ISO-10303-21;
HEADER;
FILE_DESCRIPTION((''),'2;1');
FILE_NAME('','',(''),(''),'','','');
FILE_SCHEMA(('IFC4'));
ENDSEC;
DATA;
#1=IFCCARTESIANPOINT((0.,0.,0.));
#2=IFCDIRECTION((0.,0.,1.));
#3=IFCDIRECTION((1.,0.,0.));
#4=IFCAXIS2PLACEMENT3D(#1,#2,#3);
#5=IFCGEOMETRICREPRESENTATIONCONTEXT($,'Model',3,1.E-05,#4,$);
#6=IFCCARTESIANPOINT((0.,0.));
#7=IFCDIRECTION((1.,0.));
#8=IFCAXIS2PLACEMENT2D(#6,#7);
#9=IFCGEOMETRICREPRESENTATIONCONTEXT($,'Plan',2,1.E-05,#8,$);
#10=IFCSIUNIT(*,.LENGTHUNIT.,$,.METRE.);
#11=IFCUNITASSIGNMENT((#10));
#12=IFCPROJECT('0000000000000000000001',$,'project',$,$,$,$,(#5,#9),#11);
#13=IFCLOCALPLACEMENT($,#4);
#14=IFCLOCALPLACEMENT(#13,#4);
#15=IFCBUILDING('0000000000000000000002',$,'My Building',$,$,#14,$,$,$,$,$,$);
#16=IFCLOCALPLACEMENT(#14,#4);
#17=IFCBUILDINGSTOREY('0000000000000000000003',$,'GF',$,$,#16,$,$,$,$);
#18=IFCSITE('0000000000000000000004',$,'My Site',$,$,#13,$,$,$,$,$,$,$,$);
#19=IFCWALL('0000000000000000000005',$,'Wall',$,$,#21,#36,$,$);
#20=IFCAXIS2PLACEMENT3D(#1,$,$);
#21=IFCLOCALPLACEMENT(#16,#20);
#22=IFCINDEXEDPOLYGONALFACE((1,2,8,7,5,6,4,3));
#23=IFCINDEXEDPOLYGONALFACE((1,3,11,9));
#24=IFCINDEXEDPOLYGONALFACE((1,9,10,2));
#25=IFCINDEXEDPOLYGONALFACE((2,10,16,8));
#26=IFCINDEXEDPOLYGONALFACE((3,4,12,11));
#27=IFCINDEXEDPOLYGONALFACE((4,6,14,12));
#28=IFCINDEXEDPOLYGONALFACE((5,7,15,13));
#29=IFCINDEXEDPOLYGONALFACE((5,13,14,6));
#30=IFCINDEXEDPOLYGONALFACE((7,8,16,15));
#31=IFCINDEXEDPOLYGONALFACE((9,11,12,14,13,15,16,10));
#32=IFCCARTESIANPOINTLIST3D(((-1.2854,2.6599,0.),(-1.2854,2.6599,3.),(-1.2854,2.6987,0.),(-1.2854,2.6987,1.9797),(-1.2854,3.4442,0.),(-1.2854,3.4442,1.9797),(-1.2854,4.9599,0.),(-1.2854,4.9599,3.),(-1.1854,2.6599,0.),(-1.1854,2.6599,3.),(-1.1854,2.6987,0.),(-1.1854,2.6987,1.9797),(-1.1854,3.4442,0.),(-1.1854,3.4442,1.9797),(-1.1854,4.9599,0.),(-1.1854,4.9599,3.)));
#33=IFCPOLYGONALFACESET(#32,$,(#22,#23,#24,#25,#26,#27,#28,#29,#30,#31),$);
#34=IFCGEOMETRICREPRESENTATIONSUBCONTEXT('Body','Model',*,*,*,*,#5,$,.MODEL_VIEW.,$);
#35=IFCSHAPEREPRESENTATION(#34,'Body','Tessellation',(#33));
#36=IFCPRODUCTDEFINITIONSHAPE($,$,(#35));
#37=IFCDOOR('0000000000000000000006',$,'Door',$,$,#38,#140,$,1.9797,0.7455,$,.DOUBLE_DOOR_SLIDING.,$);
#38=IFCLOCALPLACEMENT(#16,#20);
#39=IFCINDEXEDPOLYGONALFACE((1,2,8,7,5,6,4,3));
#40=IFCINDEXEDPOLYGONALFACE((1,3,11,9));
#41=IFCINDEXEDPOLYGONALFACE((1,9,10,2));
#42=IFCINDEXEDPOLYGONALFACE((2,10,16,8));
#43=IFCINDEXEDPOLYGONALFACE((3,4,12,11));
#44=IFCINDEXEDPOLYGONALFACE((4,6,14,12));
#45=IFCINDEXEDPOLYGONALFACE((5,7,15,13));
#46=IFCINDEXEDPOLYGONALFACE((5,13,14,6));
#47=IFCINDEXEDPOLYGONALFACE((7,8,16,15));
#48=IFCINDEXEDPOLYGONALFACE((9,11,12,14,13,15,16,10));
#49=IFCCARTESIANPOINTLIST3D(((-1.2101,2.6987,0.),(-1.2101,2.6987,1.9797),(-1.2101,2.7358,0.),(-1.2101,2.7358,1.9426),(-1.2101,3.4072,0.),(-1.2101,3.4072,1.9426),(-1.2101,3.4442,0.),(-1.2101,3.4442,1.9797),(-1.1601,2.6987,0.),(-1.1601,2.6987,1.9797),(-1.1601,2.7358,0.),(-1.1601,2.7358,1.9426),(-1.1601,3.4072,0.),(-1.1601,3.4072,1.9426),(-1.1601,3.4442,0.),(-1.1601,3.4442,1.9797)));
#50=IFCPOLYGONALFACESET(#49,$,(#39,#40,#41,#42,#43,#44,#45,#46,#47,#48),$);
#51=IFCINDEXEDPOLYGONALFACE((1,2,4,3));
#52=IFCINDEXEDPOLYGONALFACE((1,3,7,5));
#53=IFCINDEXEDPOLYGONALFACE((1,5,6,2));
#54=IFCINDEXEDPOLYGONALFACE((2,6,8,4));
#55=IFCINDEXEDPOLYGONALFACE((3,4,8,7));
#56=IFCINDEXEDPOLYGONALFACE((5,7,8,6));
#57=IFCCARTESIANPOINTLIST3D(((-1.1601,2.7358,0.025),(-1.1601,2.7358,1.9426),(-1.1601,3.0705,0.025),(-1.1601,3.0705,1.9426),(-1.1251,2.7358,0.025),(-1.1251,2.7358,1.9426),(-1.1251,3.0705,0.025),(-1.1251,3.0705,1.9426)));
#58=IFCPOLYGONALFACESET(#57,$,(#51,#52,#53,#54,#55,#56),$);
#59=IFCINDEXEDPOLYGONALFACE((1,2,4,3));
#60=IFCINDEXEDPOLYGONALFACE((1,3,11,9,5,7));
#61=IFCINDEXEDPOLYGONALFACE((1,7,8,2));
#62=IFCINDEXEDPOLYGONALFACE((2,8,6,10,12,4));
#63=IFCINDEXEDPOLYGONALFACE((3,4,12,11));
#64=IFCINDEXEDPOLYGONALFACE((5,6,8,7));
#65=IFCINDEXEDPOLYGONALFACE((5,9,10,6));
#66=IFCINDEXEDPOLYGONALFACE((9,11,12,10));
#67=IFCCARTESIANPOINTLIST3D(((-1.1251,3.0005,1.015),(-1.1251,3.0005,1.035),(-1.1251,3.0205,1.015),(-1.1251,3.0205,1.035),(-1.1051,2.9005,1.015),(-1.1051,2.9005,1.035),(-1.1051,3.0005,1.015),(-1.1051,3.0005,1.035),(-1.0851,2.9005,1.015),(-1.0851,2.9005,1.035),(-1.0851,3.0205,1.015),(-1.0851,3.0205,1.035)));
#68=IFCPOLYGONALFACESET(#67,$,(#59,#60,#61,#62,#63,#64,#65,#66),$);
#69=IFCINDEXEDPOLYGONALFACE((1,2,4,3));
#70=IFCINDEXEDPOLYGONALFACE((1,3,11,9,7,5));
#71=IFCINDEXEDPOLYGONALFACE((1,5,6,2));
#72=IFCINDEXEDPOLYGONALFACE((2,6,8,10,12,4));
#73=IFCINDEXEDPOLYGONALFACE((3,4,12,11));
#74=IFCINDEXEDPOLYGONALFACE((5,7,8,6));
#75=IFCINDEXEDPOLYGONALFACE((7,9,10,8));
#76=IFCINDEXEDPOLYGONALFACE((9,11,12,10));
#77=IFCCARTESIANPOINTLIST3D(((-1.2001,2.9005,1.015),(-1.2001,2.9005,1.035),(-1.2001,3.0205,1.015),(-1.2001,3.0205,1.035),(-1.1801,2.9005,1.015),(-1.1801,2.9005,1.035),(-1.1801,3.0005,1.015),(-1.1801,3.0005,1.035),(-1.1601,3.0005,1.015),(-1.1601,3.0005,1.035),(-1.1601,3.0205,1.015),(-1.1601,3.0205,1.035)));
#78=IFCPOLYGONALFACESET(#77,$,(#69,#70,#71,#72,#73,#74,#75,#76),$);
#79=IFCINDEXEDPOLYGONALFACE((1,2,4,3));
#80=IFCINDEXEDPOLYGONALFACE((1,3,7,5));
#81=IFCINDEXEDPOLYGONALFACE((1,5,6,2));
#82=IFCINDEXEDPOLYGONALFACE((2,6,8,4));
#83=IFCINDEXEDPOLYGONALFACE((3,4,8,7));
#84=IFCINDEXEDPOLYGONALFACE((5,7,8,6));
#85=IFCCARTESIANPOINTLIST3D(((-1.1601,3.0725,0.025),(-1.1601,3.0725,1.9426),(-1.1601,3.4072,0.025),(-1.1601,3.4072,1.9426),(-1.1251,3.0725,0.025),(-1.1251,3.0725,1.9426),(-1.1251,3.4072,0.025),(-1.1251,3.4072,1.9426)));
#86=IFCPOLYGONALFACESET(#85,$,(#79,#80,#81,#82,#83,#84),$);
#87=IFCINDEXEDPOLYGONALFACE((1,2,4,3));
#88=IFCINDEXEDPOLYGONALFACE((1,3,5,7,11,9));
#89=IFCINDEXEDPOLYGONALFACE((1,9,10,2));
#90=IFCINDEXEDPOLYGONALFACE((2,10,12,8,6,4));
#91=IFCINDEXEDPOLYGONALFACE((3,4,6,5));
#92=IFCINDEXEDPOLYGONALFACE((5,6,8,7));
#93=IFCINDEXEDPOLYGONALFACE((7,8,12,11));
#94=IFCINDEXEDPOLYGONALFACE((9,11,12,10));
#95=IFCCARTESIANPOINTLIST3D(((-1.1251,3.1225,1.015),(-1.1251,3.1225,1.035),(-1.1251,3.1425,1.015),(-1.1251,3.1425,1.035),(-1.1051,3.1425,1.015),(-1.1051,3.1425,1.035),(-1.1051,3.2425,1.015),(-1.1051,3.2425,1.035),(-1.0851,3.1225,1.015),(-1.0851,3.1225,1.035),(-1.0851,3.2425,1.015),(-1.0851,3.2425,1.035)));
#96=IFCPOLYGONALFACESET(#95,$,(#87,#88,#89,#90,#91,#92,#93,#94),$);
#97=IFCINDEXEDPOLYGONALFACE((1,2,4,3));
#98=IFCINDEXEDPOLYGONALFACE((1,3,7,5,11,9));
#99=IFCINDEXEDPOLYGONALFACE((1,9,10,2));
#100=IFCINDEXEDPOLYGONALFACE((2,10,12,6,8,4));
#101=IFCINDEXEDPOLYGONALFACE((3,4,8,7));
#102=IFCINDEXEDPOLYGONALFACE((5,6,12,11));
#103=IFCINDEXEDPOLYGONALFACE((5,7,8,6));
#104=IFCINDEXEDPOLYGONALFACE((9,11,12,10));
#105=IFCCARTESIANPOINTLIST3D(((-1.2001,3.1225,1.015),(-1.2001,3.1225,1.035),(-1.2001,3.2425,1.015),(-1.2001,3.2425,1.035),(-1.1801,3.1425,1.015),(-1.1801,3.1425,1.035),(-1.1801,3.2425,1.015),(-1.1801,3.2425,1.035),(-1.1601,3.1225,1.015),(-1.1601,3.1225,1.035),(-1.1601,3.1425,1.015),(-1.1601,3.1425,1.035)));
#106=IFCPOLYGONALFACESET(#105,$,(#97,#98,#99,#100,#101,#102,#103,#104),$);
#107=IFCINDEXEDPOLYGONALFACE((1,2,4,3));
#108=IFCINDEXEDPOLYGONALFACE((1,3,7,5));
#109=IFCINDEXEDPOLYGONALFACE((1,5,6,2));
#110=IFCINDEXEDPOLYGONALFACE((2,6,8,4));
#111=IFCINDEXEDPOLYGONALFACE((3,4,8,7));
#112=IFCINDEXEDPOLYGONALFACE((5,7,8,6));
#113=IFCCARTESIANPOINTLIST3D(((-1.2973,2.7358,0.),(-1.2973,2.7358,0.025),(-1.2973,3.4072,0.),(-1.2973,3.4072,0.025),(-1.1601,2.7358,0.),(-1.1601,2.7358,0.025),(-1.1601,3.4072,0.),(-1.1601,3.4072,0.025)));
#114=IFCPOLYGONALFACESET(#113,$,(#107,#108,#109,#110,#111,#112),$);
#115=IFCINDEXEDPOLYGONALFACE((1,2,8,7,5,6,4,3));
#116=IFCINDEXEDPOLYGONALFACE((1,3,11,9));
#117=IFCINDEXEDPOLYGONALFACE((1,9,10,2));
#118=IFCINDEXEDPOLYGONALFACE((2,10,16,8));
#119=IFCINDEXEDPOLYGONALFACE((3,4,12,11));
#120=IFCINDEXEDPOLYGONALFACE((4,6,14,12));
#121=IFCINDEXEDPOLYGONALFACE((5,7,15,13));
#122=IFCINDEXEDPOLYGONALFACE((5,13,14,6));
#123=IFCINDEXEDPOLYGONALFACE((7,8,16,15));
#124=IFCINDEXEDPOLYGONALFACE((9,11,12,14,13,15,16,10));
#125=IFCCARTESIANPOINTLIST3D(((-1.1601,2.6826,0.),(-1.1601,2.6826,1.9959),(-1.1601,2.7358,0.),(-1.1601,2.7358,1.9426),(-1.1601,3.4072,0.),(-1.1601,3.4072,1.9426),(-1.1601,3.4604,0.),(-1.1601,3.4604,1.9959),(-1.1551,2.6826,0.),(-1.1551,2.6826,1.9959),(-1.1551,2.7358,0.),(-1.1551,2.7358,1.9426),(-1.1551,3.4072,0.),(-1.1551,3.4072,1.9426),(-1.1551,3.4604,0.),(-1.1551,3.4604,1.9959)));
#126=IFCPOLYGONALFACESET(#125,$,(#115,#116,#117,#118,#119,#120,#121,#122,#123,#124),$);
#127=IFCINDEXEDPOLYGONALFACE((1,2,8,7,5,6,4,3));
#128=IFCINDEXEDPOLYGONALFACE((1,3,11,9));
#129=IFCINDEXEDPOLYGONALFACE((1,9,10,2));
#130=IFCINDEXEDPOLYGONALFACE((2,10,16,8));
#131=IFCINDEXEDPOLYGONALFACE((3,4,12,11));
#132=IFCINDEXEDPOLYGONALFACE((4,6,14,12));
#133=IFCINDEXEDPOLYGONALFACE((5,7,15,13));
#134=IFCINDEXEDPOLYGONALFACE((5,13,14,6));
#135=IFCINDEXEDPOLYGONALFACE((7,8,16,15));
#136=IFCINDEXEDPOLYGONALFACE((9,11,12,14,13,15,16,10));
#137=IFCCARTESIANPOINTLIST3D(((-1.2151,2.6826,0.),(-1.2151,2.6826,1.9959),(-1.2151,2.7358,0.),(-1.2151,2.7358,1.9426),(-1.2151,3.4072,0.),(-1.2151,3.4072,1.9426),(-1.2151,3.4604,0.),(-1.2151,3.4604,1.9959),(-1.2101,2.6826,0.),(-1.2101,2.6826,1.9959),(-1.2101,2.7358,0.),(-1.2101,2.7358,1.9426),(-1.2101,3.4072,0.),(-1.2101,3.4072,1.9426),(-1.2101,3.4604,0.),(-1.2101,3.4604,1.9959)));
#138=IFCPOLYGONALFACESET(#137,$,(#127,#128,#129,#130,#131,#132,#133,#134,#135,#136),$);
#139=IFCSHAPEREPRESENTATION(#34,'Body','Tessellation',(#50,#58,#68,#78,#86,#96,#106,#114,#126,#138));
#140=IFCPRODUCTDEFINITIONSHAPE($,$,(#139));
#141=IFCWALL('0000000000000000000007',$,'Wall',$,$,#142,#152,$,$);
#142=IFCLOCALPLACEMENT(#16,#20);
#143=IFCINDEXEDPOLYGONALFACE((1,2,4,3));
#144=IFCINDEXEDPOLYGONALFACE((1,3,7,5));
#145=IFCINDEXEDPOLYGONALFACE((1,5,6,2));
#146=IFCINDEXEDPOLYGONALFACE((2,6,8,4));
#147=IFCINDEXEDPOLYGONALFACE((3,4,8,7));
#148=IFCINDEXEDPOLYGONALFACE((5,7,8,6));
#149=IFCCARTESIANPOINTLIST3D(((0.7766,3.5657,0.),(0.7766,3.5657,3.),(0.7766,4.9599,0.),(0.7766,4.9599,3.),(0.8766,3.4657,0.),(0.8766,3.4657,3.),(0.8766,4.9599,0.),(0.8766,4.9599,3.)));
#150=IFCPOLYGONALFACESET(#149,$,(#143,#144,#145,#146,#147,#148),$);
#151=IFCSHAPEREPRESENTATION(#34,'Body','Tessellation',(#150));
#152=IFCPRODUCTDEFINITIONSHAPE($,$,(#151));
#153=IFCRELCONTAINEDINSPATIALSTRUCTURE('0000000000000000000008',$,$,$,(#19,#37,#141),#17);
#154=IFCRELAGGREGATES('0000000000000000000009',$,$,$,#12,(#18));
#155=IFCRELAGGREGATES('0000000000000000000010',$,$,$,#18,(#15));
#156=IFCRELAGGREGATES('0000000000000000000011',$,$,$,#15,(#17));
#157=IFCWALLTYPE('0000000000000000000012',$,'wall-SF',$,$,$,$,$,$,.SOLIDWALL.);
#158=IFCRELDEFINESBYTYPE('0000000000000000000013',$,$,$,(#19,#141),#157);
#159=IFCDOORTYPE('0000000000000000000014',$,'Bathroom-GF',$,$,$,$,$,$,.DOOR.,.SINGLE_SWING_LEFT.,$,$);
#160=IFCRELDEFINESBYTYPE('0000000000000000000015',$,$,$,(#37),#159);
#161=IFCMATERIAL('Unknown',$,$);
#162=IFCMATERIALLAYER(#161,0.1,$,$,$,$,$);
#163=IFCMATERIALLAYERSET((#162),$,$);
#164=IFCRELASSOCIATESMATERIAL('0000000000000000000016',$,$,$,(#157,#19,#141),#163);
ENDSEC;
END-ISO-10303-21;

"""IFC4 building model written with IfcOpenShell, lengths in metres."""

from ifc_helpers import new_model, entity, si_unit, frame, origin_with_axes, origin_2d_with_axis, place, context, subcontext, project, spatial, line, indexed_curve, outline, extrude, shape, source, transform, mapped, material, layer, layer_set, layer_usage, type_object, type_shapes, element, fill, save


model = new_model("IFC4")

# Units and contexts
model_context = context("Model", 3, precision=1e-05, world=origin_with_axes())
plan_context = context("Plan", 2, precision=1e-05, world=origin_2d_with_axis())
body_context_1 = subcontext(model_context, "Body", "Model", "MODEL_VIEW")
body_context_2 = subcontext(plan_context, "Body", "Plan", "PLAN_VIEW")
ifc_project = project(units=[si_unit("LENGTHUNIT", "METRE")], contexts=[model_context, plan_context])

# Site, building, storey
site_placement = place(None, origin_with_axes())
site = spatial("IfcSite", under=ifc_project, at=site_placement, Name="My Site")
building_placement = place(site_placement, origin_with_axes())
building = spatial("IfcBuilding", under=site, at=building_placement, Name="My Building")
storey_placement = place(building_placement, origin_with_axes())
storey = spatial("IfcBuildingStorey", under=building, at=storey_placement, Name="GF")

# Shared definitions
ifc_material = material(Name="Unknown")

# Shared definitions
ifc_layer_1 = layer(ifc_material, 0.1)
ifc_layer_set_1 = layer_set([ifc_layer_1])
wall_type = type_object("IfcWallType", Name="wall-SF", PredefinedType="SOLIDWALL", material=ifc_layer_set_1)

# Wall, opening, door
ifc_layer_usage_1 = layer_usage(ifc_layer_set_1, "AXIS2", "POSITIVE", 0.0)
wall_1_placement = place(storey_placement, frame((-1.1854, 2.6599, 0.0), z_axis=(0.0, 0.0, 1.0), x_axis=(0.0, 1.0, 0.0)))
wall_1 = element("IfcWall", 1, at=wall_1_placement, inside=storey, type_object=wall_type, material=ifc_layer_usage_1, Name="Wall", context=body_context_1, shape_type="SweptSolid", body=[
    extrude(outline(indexed_curve([(0.0, 0.0), (0.0, 0.1), (2.3, 0.1), (2.3, 0.0)], segments=[line(1, 2, 3, 4, 1)])), origin_with_axes(), (0.0, 0.0, 1.0), 3.0),
])
shared_shape_1 = source(origin_with_axes(), body_context_1, "Body", "SweptSolid", [
    extrude(outline(indexed_curve([(0.0, 0.0), (0.7455, 0.0), (0.7455, 1.9797), (0.0, 1.9797)], segments=[line(1, 2, 3, 4, 1)])), frame((0.0, -0.6, 0.0), z_axis=(0.0, -1.0, 0.0), x_axis=(1.0, 0.0, 0.0)), (0.0, 0.0, -1.0), 1.2),
])
opening_1_placement = place(wall_1_placement, frame((0.0388, -0.0253, 0.0), z_axis=(0.0, 0.0, 1.0), x_axis=(1.0, 0.0, 0.0)))
opening_1 = element("IfcOpeningElement", 2, at=opening_1_placement, cuts=wall_1, PredefinedType="OPENING", context=body_context_1, shape_type="MappedRepresentation", body=[
    mapped(shared_shape_1, transform((0.0, 0.0, 0.0), x_axis=(1.0, 0.0, 0.0), y_axis=(0.0, 1.0, 0.0), z_axis=(0.0, 0.0, 1.0), scale=1.0)),
])
door_type_1 = type_object("IfcDoorType", Name="Bathroom-GF", OperationType="SINGLE_SWING_LEFT", PredefinedType="DOOR")
shared_shape_2 = source(origin_with_axes(), body_context_1, "Body", "SweptSolid", [
    extrude(outline(indexed_curve([(0.0, 0.0), (0.0, 1.9797), (0.7455, 1.9797), (0.7455, 0.0), (0.7084, 0.0), (0.7084, 1.9426), (0.0371, 1.9426), (0.0371, 0.0)], segments=[line(1, 2, 3, 4, 5, 6, 7, 8, 1)])), frame((0.0, 0.0, 0.0), z_axis=(0.0, -1.0, 0.0), x_axis=(1.0, 0.0, 0.0)), (0.0, 0.0, -1.0), 0.05),
    extrude(outline(indexed_curve([(0.0, 0.0), (0.3347, 0.0), (0.3347, 0.035), (0.0, 0.035)], segments=[line(1, 2, 3, 4, 1)])), frame((0.0371, -0.035, 0.025), z_axis=(0.0, 0.0, 1.0), x_axis=(1.0, 0.0, 0.0)), (0.0, 0.0, 1.0), 1.9176),
    extrude(outline(indexed_curve([(0.0, 0.0), (0.0, -0.04), (-0.12, -0.04), (-0.12, -0.02), (-0.02, -0.02), (-0.02, 0.0)], segments=[line(1, 2, 3, 4, 5, 6, 1)])), frame((0.3218, -0.035, 1.015), z_axis=(0.0, 0.0, 1.0), x_axis=(1.0, 0.0, 0.0)), (0.0, 0.0, 1.0), 0.02),
    extrude(outline(indexed_curve([(0.0, 0.0), (0.0, 0.04), (-0.12, 0.04), (-0.12, 0.02), (-0.02, 0.02), (-0.02, 0.0)], segments=[line(1, 2, 3, 4, 5, 6, 1)])), frame((0.3218, 0.0, 1.015), z_axis=(0.0, 0.0, 1.0), x_axis=(1.0, 0.0, 0.0)), (0.0, 0.0, 1.0), 0.02),
    extrude(outline(indexed_curve([(0.0, 0.0), (-0.3347, 0.0), (-0.3347, 0.035), (0.0, 0.035)], segments=[line(1, 2, 3, 4, 1)])), frame((0.7084, -0.035, 0.025), z_axis=(0.0, 0.0, 1.0), x_axis=(1.0, 0.0, 0.0)), (0.0, 0.0, 1.0), 1.9176),
    extrude(outline(indexed_curve([(0.0, 0.0), (0.0, -0.04), (0.12, -0.04), (0.12, -0.02), (0.02, -0.02), (0.02, 0.0)], segments=[line(1, 2, 3, 4, 5, 6, 1)])), frame((0.4238, -0.035, 1.015), z_axis=(0.0, 0.0, 1.0), x_axis=(1.0, 0.0, 0.0)), (0.0, 0.0, 1.0), 0.02),
    extrude(outline(indexed_curve([(0.0, 0.0), (0.0, 0.04), (0.12, 0.04), (0.12, 0.02), (0.02, 0.02), (0.02, 0.0)], segments=[line(1, 2, 3, 4, 5, 6, 1)])), frame((0.4238, 0.0, 1.015), z_axis=(0.0, 0.0, 1.0), x_axis=(1.0, 0.0, 0.0)), (0.0, 0.0, 1.0), 0.02),
    extrude(outline(indexed_curve([(0.0, 0.0), (0.6713, 0.0), (0.6713, 0.1372), (0.0, 0.1372)], segments=[line(1, 2, 3, 4, 1)])), frame((0.0371, 0.0, 0.0), z_axis=(0.0, 0.0, 1.0), x_axis=(1.0, 0.0, 0.0)), (0.0, 0.0, 1.0), 0.025),
    extrude(outline(indexed_curve([(0.0, 0.0), (0.0, 1.9959), (0.7778, 1.9959), (0.7778, 0.0), (0.7246, 0.0), (0.7246, 1.9426), (0.0532, 1.9426), (0.0532, 0.0)], segments=[line(1, 2, 3, 4, 5, 6, 7, 8, 1)])), frame((-0.0162, -0.005, 0.0), z_axis=(0.0, -1.0, 0.0), x_axis=(1.0, 0.0, 0.0)), (0.0, 0.0, -1.0), 0.005),
    extrude(outline(indexed_curve([(0.0, 0.0), (0.0, 1.9959), (0.7778, 1.9959), (0.7778, 0.0), (0.7246, 0.0), (0.7246, 1.9426), (0.0532, 1.9426), (0.0532, 0.0)], segments=[line(1, 2, 3, 4, 5, 6, 7, 8, 1)])), frame((-0.0162, 0.05, 0.0), z_axis=(0.0, -1.0, 0.0), x_axis=(1.0, 0.0, 0.0)), (0.0, 0.0, -1.0), 0.005),
])
shared_shape_3 = source(origin_with_axes(), body_context_2, "Body", "Curve2D", [
    entity("IfcIndexedPolyCurve", entity("IfcCartesianPointList2D", [[0.0, 0.0], [0.0371, 0.0], [0.0371, 0.05], [0.0, 0.05]]), [entity("IfcLineIndex", [1, 2, 3, 4, 1])]),
    entity("IfcIndexedPolyCurve", entity("IfcCartesianPointList2D", [[0.7455, 0.0], [0.7084, 0.0], [0.7084, 0.05], [0.7455, 0.05]]), [entity("IfcLineIndex", [1, 2, 3, 4, 1])]),
    entity("IfcIndexedPolyCurve", entity("IfcCartesianPointList2D", [[-0.1307, -0.035], [0.2049, -0.035], [0.2049, 0.0], [-0.1307, 0.0]]), [entity("IfcLineIndex", [1, 2, 3, 4, 1])]),
    entity("IfcIndexedPolyCurve", entity("IfcCartesianPointList2D", [[0.8763, -0.035], [0.5406, -0.035], [0.5406, 0.0], [0.8763, 0.0]]), [entity("IfcLineIndex", [1, 2, 3, 4, 1])]),
])
type_shapes(door_type_1, [shared_shape_2, shared_shape_3])
door_1_placement = place(opening_1_placement, frame((0.0, 0.0, 0.0), z_axis=(0.0, 0.0, 1.0), x_axis=(1.0, 0.0, 0.0)))
door_1 = element("IfcDoor", 3, at=door_1_placement, inside=storey, type_object=door_type_1, Name="Door", OperationType="DOUBLE_DOOR_SLIDING", OverallHeight=1.9797, OverallWidth=0.7455, shapes=[
    shape(body_context_1, "Body", "MappedRepresentation", [mapped(shared_shape_2, transform((0.0, 0.0, 0.0), x_axis=(1.0, 0.0, 0.0), y_axis=(0.0, 1.0, 0.0), z_axis=(0.0, 0.0, 1.0), scale=1.0))]),
    shape(body_context_2, "Body", "MappedRepresentation", [mapped(shared_shape_3, transform((0.0, 0.0, 0.0), x_axis=(1.0, 0.0, 0.0), y_axis=(0.0, 1.0, 0.0), z_axis=(0.0, 0.0, 1.0), scale=1.0))]),
])
fill(opening_1, door_1)

# Wall
ifc_layer_usage_2 = layer_usage(ifc_layer_set_1, "AXIS2", "POSITIVE", 0.0)
wall_2_placement = place(storey_placement, frame((0.7766, 5.0599, 0.0), z_axis=(0.0, 0.0, 1.0), x_axis=(0.0, -1.0, 0.0)))
element("IfcWall", 4, at=wall_2_placement, inside=storey, type_object=wall_type, material=ifc_layer_usage_2, Name="Wall", context=body_context_1, shape_type="SweptSolid", body=[
    extrude(outline(indexed_curve([(0.1, 0.0), (0.1, 0.1), (1.5942, 0.1), (1.4942, 0.0)], segments=[line(1, 2, 3, 4, 1)])), origin_with_axes(), (0.0, 0.0, 1.0), 3.0),
])

save(model, "model.ifc")
